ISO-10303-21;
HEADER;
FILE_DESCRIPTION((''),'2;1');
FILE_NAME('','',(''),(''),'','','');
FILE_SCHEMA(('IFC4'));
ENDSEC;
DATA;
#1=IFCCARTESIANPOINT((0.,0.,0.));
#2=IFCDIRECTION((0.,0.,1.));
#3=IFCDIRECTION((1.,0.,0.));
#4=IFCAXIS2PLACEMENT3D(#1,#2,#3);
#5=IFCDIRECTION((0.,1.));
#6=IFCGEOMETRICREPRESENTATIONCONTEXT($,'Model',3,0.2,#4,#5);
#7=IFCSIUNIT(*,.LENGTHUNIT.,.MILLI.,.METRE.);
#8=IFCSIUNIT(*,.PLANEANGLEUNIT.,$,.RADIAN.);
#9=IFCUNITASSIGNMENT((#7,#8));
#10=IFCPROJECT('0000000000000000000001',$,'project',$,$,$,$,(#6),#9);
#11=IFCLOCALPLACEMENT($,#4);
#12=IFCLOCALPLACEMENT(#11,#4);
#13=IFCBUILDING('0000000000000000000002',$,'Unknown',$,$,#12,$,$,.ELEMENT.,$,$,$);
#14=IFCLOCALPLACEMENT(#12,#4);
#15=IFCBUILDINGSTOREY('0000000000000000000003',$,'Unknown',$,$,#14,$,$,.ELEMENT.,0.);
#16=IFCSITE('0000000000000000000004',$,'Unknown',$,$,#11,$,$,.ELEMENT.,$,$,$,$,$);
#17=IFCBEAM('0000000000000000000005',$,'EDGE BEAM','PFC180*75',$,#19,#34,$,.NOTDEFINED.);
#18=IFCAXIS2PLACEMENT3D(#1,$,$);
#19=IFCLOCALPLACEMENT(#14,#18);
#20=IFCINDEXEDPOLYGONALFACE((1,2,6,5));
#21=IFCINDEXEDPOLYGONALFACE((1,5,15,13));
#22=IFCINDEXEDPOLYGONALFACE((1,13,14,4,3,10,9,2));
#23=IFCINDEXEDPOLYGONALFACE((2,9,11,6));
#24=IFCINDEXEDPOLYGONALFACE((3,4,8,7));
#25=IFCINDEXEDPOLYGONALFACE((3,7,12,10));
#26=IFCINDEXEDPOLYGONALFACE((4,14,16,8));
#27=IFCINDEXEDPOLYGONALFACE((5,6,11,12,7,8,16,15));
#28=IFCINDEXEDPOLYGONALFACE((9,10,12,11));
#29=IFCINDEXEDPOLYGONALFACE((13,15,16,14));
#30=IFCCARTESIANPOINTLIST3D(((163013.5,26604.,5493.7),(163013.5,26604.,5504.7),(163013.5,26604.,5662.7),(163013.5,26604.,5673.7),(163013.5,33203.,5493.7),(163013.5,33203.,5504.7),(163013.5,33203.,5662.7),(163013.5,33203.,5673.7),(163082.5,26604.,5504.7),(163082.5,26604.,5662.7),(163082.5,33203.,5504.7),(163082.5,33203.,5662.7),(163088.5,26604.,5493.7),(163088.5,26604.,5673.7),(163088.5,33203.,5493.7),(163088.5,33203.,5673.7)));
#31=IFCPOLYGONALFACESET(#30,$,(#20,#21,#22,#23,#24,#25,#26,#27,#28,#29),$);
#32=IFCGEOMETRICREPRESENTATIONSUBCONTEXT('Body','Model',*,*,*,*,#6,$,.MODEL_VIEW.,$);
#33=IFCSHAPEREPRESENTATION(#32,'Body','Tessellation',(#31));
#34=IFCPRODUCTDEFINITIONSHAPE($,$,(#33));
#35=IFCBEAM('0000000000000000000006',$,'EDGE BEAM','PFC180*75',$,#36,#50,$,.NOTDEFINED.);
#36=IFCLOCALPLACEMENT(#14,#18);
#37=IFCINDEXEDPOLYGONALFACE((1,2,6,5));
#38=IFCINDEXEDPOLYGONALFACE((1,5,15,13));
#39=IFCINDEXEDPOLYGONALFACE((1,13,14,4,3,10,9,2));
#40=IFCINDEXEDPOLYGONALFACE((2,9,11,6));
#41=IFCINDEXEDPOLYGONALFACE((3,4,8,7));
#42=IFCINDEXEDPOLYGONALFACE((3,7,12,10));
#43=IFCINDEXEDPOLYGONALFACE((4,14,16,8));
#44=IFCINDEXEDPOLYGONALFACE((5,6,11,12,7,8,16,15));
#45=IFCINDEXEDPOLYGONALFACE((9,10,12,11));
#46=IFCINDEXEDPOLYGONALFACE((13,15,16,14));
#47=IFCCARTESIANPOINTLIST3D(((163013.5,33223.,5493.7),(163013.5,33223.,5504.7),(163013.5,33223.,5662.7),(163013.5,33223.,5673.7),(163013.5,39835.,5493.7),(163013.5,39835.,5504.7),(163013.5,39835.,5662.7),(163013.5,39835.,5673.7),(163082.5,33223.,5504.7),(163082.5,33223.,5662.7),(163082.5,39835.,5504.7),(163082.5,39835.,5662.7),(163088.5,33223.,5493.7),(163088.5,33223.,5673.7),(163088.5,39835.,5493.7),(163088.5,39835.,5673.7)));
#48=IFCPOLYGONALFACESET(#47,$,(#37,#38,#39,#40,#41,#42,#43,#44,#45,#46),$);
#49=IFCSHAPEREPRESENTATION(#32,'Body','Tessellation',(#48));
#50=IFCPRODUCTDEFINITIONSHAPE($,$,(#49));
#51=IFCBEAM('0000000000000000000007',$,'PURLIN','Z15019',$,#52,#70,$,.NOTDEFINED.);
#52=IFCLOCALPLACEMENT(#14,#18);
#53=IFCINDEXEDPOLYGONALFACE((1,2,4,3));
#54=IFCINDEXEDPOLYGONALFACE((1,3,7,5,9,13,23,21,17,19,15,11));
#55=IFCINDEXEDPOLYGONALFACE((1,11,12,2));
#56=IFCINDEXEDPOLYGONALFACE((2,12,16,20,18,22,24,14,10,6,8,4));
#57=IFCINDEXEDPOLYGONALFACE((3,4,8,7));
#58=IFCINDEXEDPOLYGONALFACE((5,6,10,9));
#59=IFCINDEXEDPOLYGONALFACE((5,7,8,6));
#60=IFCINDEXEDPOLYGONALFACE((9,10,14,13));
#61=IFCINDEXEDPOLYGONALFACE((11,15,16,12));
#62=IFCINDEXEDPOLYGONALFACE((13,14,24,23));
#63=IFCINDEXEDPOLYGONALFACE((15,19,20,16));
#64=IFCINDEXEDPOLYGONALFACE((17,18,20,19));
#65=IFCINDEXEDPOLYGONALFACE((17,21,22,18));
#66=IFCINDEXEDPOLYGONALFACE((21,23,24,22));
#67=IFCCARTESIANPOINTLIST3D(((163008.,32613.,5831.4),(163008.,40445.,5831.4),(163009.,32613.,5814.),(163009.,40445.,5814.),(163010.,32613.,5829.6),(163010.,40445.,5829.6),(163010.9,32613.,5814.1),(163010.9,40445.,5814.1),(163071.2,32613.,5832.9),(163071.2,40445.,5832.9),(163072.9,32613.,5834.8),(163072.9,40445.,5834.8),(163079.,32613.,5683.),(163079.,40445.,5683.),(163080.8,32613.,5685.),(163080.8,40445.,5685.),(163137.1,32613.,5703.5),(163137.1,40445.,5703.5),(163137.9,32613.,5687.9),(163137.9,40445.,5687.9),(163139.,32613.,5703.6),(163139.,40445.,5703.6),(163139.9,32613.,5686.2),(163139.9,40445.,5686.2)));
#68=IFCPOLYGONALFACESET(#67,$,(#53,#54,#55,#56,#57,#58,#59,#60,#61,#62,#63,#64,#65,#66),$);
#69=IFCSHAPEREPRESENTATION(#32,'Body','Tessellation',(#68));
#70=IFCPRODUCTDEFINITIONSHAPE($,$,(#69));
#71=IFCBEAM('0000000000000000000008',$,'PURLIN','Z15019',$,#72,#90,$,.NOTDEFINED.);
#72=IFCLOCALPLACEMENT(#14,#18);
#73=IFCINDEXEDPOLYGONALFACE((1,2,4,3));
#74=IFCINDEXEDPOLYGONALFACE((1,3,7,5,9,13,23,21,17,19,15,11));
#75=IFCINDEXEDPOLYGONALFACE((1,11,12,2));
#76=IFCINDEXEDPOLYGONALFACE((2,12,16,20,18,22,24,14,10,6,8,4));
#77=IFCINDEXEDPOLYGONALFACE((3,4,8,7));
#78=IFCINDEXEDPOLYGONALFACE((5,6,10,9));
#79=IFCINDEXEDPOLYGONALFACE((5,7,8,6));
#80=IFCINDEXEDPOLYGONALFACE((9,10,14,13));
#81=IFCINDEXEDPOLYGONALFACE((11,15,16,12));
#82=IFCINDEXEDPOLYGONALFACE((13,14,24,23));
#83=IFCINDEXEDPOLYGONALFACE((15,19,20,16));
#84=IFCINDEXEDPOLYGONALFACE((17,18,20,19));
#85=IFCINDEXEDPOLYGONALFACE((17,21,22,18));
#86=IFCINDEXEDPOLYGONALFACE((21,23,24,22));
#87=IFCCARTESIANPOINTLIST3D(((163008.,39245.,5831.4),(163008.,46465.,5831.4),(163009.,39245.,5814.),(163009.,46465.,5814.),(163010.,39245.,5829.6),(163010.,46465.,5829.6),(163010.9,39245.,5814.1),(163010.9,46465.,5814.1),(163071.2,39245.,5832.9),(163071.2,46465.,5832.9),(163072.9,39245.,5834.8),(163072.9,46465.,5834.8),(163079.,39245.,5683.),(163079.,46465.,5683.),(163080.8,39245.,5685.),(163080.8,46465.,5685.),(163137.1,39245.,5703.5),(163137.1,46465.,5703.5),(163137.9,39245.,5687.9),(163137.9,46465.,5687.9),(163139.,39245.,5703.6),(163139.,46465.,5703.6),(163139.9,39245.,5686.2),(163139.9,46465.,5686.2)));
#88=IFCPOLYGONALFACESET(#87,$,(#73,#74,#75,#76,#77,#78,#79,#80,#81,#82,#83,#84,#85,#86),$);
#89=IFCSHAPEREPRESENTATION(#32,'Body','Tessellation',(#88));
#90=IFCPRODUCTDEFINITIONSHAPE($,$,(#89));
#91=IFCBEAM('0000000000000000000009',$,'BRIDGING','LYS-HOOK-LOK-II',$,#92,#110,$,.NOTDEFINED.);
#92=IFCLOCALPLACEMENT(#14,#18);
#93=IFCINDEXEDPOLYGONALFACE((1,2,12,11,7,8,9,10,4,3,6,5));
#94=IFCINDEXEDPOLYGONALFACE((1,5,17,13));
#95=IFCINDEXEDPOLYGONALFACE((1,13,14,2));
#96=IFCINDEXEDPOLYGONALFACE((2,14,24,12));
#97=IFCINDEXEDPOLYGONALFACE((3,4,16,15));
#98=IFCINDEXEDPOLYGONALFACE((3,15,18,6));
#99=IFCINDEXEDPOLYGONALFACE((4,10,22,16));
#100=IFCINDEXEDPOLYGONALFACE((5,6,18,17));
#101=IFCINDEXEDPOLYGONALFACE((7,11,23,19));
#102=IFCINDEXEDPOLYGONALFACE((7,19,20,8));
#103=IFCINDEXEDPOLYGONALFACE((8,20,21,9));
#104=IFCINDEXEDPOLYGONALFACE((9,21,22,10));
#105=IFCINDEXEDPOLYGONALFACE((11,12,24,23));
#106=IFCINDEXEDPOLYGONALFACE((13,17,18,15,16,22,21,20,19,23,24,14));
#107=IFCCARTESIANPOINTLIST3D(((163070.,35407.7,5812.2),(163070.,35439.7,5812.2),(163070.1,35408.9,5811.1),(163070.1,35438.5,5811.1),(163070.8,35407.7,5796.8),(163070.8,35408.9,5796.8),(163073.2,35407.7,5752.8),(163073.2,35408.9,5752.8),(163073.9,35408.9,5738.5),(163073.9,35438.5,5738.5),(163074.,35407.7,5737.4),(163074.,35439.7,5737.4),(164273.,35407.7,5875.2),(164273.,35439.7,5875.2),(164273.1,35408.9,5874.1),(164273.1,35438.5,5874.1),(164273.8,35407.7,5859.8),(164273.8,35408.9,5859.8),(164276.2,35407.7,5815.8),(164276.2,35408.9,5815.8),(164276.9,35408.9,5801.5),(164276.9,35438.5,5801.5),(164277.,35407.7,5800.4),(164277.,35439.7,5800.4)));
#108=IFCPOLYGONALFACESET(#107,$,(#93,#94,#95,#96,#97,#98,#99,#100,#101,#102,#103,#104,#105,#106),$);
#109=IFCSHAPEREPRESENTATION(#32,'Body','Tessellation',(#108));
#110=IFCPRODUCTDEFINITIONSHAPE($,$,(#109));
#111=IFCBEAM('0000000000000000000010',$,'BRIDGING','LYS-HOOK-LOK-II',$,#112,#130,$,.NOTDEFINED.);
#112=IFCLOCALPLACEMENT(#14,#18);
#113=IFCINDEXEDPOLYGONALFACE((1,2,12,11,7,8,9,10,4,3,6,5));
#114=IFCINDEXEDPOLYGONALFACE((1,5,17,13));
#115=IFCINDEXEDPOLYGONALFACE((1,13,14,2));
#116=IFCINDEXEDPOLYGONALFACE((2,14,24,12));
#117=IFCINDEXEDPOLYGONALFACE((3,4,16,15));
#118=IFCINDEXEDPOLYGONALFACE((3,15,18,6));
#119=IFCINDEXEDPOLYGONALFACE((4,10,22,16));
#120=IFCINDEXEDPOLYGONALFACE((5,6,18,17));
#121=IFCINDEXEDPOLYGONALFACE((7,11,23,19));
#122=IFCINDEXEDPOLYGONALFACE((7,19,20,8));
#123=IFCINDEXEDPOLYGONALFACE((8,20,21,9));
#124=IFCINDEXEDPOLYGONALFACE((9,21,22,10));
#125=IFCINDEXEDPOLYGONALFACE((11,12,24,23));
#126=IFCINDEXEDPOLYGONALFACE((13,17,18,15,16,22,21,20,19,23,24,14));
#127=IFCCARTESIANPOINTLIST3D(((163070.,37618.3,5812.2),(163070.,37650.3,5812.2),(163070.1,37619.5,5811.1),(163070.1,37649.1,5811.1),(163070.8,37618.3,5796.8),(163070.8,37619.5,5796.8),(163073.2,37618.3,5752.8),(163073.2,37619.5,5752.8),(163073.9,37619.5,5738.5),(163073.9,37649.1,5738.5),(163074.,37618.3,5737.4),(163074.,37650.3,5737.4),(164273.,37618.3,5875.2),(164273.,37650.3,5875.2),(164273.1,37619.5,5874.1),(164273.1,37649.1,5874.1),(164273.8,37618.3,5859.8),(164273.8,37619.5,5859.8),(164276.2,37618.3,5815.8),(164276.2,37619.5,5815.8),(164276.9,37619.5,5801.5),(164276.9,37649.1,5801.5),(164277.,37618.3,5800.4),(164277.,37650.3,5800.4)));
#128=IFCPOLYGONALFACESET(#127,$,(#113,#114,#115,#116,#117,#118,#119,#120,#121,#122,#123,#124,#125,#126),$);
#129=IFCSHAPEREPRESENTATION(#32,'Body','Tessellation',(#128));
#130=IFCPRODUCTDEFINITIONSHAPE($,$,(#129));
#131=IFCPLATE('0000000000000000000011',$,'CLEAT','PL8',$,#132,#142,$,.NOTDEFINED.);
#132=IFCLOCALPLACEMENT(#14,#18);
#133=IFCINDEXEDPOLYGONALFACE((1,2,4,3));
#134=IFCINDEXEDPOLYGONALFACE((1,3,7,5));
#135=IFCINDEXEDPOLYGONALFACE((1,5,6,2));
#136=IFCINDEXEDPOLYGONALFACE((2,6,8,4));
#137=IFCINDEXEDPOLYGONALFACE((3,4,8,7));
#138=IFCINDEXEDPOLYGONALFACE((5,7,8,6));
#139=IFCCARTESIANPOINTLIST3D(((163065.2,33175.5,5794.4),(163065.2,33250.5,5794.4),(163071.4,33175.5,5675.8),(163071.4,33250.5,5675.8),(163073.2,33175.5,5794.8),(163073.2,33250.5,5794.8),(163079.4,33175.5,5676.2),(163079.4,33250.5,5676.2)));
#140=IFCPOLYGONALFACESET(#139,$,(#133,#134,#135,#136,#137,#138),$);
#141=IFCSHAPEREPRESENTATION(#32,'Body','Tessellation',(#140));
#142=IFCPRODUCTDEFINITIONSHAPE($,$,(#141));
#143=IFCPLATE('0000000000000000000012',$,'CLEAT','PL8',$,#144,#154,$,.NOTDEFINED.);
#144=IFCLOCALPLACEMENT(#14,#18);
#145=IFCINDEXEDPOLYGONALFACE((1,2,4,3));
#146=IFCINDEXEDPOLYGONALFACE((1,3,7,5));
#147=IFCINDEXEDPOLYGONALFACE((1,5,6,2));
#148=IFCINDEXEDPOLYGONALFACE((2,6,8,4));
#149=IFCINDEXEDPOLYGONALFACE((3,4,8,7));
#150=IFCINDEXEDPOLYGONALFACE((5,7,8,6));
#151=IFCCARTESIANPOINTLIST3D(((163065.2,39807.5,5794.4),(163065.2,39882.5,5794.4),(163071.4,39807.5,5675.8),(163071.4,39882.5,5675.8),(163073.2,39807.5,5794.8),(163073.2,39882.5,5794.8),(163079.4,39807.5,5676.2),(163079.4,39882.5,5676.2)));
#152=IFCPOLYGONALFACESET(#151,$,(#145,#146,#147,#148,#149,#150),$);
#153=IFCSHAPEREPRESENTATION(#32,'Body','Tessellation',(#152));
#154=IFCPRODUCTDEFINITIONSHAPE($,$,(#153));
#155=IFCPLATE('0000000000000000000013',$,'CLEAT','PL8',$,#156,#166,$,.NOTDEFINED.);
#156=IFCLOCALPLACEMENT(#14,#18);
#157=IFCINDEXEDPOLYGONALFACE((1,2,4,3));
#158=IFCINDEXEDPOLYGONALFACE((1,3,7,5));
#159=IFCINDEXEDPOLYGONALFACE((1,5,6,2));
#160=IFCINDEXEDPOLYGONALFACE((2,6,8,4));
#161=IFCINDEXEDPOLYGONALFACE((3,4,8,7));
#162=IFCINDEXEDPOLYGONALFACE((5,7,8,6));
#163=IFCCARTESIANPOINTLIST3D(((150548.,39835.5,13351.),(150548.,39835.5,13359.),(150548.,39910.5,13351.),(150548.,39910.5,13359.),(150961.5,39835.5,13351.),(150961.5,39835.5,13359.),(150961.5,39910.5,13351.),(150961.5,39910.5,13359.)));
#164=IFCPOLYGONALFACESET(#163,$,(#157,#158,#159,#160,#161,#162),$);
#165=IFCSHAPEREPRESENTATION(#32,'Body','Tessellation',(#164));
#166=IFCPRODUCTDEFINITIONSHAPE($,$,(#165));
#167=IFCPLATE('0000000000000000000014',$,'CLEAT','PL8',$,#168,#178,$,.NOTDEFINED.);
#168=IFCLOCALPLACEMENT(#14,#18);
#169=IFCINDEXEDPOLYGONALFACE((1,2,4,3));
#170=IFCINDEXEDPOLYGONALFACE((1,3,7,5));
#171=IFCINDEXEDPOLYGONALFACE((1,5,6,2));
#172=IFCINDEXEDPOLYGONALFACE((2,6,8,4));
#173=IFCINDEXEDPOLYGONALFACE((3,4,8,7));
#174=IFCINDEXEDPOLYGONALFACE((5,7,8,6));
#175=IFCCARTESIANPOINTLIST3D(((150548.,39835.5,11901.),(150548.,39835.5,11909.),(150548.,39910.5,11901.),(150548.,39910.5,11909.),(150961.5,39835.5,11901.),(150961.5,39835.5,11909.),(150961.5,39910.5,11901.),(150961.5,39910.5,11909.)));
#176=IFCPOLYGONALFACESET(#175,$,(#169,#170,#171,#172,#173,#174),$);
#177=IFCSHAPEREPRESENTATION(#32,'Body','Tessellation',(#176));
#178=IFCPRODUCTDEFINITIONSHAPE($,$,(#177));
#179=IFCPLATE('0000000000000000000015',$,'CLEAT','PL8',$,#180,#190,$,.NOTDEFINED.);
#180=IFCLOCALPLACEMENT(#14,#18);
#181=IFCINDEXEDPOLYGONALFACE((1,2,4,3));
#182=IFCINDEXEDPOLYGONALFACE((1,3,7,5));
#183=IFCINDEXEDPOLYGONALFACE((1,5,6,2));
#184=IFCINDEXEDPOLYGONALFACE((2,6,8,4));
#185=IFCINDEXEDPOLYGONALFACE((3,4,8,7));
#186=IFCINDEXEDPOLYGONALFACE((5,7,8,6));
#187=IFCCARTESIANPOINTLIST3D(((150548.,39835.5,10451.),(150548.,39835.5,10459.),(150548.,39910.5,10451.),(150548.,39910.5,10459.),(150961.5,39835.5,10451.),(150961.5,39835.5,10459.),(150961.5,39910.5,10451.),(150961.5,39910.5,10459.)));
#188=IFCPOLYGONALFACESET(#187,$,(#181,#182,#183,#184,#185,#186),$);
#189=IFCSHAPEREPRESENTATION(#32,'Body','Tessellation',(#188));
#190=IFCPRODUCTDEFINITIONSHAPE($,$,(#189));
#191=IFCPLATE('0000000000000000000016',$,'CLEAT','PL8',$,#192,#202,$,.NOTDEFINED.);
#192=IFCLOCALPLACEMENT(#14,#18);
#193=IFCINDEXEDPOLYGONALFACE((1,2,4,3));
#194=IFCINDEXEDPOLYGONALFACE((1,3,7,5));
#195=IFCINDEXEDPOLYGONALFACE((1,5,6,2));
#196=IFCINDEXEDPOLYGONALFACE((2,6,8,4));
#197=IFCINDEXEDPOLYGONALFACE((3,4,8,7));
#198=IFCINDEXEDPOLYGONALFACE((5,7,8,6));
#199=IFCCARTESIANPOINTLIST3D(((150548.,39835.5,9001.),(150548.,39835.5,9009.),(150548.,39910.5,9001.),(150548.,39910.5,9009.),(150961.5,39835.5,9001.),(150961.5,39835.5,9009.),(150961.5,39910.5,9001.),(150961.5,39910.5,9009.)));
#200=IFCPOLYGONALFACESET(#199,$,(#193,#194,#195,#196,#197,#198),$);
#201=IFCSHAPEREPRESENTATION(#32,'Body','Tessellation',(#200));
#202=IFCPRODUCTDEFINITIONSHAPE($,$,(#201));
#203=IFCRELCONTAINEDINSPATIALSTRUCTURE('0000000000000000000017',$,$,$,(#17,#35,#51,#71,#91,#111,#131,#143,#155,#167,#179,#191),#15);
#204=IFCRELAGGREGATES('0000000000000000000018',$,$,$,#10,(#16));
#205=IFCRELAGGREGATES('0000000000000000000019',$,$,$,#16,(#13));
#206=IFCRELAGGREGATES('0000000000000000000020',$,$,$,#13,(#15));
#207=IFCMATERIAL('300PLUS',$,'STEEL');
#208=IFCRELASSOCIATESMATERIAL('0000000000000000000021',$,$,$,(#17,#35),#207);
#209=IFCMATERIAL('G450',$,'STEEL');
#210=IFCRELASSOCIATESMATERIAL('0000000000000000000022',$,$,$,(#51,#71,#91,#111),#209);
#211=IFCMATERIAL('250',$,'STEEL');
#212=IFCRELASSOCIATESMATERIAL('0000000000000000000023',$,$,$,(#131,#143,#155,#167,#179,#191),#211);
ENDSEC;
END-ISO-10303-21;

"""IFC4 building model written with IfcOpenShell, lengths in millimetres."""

from ifc_helpers import new_model, si_unit, direction, frame, origin_with_axes, place, context, subcontext, project, spatial, line, indexed_curve, outline, extrude, material, element, save


model = new_model("IFC4")

# Units and contexts
model_context = context("Model", 3, precision=0.2, world=origin_with_axes(), true_north=direction((0.0, 1.0)))
body_context = subcontext(model_context, "Body", "Model", "MODEL_VIEW")
ifc_project = project(units=[si_unit("LENGTHUNIT", "METRE", prefix="MILLI"), si_unit("PLANEANGLEUNIT", "RADIAN")], contexts=[model_context])

# Site, building, storey
site_placement = place(None, origin_with_axes())
site = spatial("IfcSite", under=ifc_project, at=site_placement, Name="Unknown", CompositionType="ELEMENT")
building_placement = place(site_placement, origin_with_axes())
building = spatial("IfcBuilding", under=site, at=building_placement, Name="Unknown", CompositionType="ELEMENT")
storey_placement = place(building_placement, origin_with_axes())
storey = spatial("IfcBuildingStorey", under=building, at=storey_placement, Name="Unknown", CompositionType="ELEMENT", Elevation=0.0)

# Beams
ifc_material_1 = material(Name="300PLUS", Category="STEEL")
beam_1_placement = place(storey_placement, frame((163051.0, 33203.0, 5583.7), z_axis=(-1.0, 0.0, 0.0), x_axis=(0.0, -1.0, 0.0)))
element("IfcBeam", 1, at=beam_1_placement, inside=storey, material=ifc_material_1, Name="EDGE BEAM", Description="PFC180*75", PredefinedType="NOTDEFINED", context=body_context, shape_type="SolidModel", body=[
    extrude(outline(indexed_curve([(-37.5, -90.0), (37.5, -90.0), (37.5, -79.0), (-31.5, -79.0), (-31.5, 79.0), (37.5, 79.0), (37.5, 90.0), (-37.5, 90.0)], segments=[line(1, 2, 3, 4, 5, 6, 7, 8, 1)])), frame((0.0, 0.0, 0.0), z_axis=(-1.0, 0.0, 0.0), x_axis=(0.0, 0.0, 1.0)), (0.0, 0.0, -1.0), 6599.0),
])
beam_2_placement = place(storey_placement, frame((163051.0, 39835.0, 5583.7), z_axis=(-1.0, 0.0, 0.0), x_axis=(0.0, -1.0, 0.0)))
element("IfcBeam", 2, at=beam_2_placement, inside=storey, material=ifc_material_1, Name="EDGE BEAM", Description="PFC180*75", PredefinedType="NOTDEFINED", context=body_context, shape_type="SolidModel", body=[
    extrude(outline(indexed_curve([(-37.5, -90.0), (37.5, -90.0), (37.5, -79.0), (-31.5, -79.0), (-31.5, 79.0), (37.5, 79.0), (37.5, 90.0), (-37.5, 90.0)], segments=[line(1, 2, 3, 4, 5, 6, 7, 8, 1)])), frame((0.0, 0.0, 0.0), z_axis=(-1.0, 0.0, 0.0), x_axis=(0.0, 0.0, 1.0)), (0.0, 0.0, -1.0), 6612.0),
])
ifc_material_2 = material(Name="G450", Category="STEEL")
beam_3_placement = place(storey_placement, frame((163076.0, 32613.0, 5758.9), z_axis=(0.99863, 0.0, 0.052336), x_axis=(0.0, 1.0, 0.0)))
element("IfcBeam", 3, at=beam_3_placement, inside=storey, material=ifc_material_2, Name="PURLIN", Description="Z15019", PredefinedType="NOTDEFINED", context=body_context, shape_type="SolidModel", body=[
    extrude(outline(indexed_curve([(60.0, -76.0), (60.0, -58.5), (58.1, -58.5), (58.1, -74.1), (0.9, -74.1), (0.9, 76.0), (-64.0, 76.0), (-64.0, 58.5), (-62.1, 58.5), (-62.1, 74.1), (-0.9, 74.1), (-0.9, -76.0)], segments=[line(1, 2, 3, 4, 5, 6, 7, 8, 9, 10, 11, 12, 1)])), frame((0.0, 0.0, 0.0), z_axis=(-1.0, 0.0, 0.0), x_axis=(0.0, 0.0, 1.0)), (0.0, 0.0, -1.0), 7832.0),
])
beam_4_placement = place(storey_placement, frame((163076.0, 39245.0, 5758.9), z_axis=(0.99863, 0.0, 0.052336), x_axis=(0.0, 1.0, 0.0)))
element("IfcBeam", 4, at=beam_4_placement, inside=storey, material=ifc_material_2, Name="PURLIN", Description="Z15019", PredefinedType="NOTDEFINED", context=body_context, shape_type="SolidModel", body=[
    extrude(outline(indexed_curve([(60.0, -76.0), (60.0, -58.5), (58.1, -58.5), (58.1, -74.1), (0.9, -74.1), (0.9, 76.0), (-64.0, 76.0), (-64.0, 58.5), (-62.1, 58.5), (-62.1, 74.1), (-0.9, 74.1), (-0.9, -76.0)], segments=[line(1, 2, 3, 4, 5, 6, 7, 8, 9, 10, 11, 12, 1)])), frame((0.0, 0.0, 0.0), z_axis=(-1.0, 0.0, 0.0), x_axis=(0.0, 0.0, 1.0)), (0.0, 0.0, -1.0), 7220.0),
])
for number, where, z_axis, x_axis, name in (
    (5, (163072.0, 35423.7, 5774.8), (0.0, -1.0, 0.0), (0.998632, 0.0, 0.052297), "BRIDGING"),
    (6, (163072.0, 37634.3, 5774.8), (0.0, -1.0, 0.0), (0.998632, 0.0, 0.052297), "BRIDGING"),
):
    element("IfcBeam", number, at=place(storey_placement, frame(where, z_axis=z_axis, x_axis=x_axis)), inside=storey, material=ifc_material_2, Name=name, Description="LYS-HOOK-LOK-II", PredefinedType="NOTDEFINED", context=body_context, shape_type="SolidModel", body=[
        extrude(outline(indexed_curve([(16.0, -37.5), (16.0, -22.0), (14.8, -22.0), (14.8, -36.3), (-14.8, -36.3), (-14.8, 36.3), (14.8, 36.3), (14.8, 22.0), (16.0, 22.0), (16.0, 37.5), (-16.0, 37.5), (-16.0, -37.5)], segments=[line(1, 2, 3, 4, 5, 6, 7, 8, 9, 10, 11, 12, 1)])), frame((0.0, 0.0, 0.0), z_axis=(-1.0, 0.0, 0.0), x_axis=(0.0, 0.0, 1.0)), (0.0, 0.0, -1.0), 1204.6),
    ])

# Plates
ifc_material_3 = material(Name="250", Category="STEEL")
for number, where, z_axis, x_axis, name in (
    (7, (163075.4, 33175.5, 5676.0), (0.998636, 0.0, 0.052205), (0.0, 1.0, 0.0), "CLEAT"),
    (8, (163075.4, 39807.5, 5676.0), (0.998636, 0.0, 0.052205), (0.0, 1.0, 0.0), "CLEAT"),
):
    element("IfcPlate", number, at=place(storey_placement, frame(where, z_axis=z_axis, x_axis=x_axis)), inside=storey, material=ifc_material_3, Name=name, Description="PL8", PredefinedType="NOTDEFINED", context=body_context, shape_type="SolidModel", body=[
        extrude(outline(indexed_curve([(0.0, 0.0), (75.0, 0.0), (75.0, 118.8), (0.0, 118.8)], segments=[line(1, 2, 3, 4, 1)])), frame((0.0, 0.0, 4.0), z_axis=(0.0, 0.0, 1.0), x_axis=(1.0, 0.0, 0.0)), (0.0, 0.0, -1.0), 8.0),
    ])
for number, where, z_axis, x_axis, name in (
    (9, (150961.5, 39835.5, 13355.0), (0.0, 0.0, 1.0), (0.0, 1.0, 0.0), "CLEAT"),
    (10, (150961.5, 39835.5, 11905.0), (0.0, 0.0, 1.0), (0.0, 1.0, 0.0), "CLEAT"),
    (11, (150961.5, 39835.5, 10455.0), (0.0, 0.0, 1.0), (0.0, 1.0, 0.0), "CLEAT"),
    (12, (150961.5, 39835.5, 9005.0), (0.0, 0.0, 1.0), (0.0, 1.0, 0.0), "CLEAT"),
):
    element("IfcPlate", number, at=place(storey_placement, frame(where, z_axis=z_axis, x_axis=x_axis)), inside=storey, material=ifc_material_3, Name=name, Description="PL8", PredefinedType="NOTDEFINED", context=body_context, shape_type="SolidModel", body=[
        extrude(outline(indexed_curve([(0.0, 0.0), (75.0, 0.0), (75.0, 413.5), (0.0, 413.5)], segments=[line(1, 2, 3, 4, 1)])), frame((0.0, 0.0, 4.0), z_axis=(0.0, 0.0, 1.0), x_axis=(1.0, 0.0, 0.0)), (0.0, 0.0, -1.0), 8.0),
    ])

save(model, "model.ifc")
